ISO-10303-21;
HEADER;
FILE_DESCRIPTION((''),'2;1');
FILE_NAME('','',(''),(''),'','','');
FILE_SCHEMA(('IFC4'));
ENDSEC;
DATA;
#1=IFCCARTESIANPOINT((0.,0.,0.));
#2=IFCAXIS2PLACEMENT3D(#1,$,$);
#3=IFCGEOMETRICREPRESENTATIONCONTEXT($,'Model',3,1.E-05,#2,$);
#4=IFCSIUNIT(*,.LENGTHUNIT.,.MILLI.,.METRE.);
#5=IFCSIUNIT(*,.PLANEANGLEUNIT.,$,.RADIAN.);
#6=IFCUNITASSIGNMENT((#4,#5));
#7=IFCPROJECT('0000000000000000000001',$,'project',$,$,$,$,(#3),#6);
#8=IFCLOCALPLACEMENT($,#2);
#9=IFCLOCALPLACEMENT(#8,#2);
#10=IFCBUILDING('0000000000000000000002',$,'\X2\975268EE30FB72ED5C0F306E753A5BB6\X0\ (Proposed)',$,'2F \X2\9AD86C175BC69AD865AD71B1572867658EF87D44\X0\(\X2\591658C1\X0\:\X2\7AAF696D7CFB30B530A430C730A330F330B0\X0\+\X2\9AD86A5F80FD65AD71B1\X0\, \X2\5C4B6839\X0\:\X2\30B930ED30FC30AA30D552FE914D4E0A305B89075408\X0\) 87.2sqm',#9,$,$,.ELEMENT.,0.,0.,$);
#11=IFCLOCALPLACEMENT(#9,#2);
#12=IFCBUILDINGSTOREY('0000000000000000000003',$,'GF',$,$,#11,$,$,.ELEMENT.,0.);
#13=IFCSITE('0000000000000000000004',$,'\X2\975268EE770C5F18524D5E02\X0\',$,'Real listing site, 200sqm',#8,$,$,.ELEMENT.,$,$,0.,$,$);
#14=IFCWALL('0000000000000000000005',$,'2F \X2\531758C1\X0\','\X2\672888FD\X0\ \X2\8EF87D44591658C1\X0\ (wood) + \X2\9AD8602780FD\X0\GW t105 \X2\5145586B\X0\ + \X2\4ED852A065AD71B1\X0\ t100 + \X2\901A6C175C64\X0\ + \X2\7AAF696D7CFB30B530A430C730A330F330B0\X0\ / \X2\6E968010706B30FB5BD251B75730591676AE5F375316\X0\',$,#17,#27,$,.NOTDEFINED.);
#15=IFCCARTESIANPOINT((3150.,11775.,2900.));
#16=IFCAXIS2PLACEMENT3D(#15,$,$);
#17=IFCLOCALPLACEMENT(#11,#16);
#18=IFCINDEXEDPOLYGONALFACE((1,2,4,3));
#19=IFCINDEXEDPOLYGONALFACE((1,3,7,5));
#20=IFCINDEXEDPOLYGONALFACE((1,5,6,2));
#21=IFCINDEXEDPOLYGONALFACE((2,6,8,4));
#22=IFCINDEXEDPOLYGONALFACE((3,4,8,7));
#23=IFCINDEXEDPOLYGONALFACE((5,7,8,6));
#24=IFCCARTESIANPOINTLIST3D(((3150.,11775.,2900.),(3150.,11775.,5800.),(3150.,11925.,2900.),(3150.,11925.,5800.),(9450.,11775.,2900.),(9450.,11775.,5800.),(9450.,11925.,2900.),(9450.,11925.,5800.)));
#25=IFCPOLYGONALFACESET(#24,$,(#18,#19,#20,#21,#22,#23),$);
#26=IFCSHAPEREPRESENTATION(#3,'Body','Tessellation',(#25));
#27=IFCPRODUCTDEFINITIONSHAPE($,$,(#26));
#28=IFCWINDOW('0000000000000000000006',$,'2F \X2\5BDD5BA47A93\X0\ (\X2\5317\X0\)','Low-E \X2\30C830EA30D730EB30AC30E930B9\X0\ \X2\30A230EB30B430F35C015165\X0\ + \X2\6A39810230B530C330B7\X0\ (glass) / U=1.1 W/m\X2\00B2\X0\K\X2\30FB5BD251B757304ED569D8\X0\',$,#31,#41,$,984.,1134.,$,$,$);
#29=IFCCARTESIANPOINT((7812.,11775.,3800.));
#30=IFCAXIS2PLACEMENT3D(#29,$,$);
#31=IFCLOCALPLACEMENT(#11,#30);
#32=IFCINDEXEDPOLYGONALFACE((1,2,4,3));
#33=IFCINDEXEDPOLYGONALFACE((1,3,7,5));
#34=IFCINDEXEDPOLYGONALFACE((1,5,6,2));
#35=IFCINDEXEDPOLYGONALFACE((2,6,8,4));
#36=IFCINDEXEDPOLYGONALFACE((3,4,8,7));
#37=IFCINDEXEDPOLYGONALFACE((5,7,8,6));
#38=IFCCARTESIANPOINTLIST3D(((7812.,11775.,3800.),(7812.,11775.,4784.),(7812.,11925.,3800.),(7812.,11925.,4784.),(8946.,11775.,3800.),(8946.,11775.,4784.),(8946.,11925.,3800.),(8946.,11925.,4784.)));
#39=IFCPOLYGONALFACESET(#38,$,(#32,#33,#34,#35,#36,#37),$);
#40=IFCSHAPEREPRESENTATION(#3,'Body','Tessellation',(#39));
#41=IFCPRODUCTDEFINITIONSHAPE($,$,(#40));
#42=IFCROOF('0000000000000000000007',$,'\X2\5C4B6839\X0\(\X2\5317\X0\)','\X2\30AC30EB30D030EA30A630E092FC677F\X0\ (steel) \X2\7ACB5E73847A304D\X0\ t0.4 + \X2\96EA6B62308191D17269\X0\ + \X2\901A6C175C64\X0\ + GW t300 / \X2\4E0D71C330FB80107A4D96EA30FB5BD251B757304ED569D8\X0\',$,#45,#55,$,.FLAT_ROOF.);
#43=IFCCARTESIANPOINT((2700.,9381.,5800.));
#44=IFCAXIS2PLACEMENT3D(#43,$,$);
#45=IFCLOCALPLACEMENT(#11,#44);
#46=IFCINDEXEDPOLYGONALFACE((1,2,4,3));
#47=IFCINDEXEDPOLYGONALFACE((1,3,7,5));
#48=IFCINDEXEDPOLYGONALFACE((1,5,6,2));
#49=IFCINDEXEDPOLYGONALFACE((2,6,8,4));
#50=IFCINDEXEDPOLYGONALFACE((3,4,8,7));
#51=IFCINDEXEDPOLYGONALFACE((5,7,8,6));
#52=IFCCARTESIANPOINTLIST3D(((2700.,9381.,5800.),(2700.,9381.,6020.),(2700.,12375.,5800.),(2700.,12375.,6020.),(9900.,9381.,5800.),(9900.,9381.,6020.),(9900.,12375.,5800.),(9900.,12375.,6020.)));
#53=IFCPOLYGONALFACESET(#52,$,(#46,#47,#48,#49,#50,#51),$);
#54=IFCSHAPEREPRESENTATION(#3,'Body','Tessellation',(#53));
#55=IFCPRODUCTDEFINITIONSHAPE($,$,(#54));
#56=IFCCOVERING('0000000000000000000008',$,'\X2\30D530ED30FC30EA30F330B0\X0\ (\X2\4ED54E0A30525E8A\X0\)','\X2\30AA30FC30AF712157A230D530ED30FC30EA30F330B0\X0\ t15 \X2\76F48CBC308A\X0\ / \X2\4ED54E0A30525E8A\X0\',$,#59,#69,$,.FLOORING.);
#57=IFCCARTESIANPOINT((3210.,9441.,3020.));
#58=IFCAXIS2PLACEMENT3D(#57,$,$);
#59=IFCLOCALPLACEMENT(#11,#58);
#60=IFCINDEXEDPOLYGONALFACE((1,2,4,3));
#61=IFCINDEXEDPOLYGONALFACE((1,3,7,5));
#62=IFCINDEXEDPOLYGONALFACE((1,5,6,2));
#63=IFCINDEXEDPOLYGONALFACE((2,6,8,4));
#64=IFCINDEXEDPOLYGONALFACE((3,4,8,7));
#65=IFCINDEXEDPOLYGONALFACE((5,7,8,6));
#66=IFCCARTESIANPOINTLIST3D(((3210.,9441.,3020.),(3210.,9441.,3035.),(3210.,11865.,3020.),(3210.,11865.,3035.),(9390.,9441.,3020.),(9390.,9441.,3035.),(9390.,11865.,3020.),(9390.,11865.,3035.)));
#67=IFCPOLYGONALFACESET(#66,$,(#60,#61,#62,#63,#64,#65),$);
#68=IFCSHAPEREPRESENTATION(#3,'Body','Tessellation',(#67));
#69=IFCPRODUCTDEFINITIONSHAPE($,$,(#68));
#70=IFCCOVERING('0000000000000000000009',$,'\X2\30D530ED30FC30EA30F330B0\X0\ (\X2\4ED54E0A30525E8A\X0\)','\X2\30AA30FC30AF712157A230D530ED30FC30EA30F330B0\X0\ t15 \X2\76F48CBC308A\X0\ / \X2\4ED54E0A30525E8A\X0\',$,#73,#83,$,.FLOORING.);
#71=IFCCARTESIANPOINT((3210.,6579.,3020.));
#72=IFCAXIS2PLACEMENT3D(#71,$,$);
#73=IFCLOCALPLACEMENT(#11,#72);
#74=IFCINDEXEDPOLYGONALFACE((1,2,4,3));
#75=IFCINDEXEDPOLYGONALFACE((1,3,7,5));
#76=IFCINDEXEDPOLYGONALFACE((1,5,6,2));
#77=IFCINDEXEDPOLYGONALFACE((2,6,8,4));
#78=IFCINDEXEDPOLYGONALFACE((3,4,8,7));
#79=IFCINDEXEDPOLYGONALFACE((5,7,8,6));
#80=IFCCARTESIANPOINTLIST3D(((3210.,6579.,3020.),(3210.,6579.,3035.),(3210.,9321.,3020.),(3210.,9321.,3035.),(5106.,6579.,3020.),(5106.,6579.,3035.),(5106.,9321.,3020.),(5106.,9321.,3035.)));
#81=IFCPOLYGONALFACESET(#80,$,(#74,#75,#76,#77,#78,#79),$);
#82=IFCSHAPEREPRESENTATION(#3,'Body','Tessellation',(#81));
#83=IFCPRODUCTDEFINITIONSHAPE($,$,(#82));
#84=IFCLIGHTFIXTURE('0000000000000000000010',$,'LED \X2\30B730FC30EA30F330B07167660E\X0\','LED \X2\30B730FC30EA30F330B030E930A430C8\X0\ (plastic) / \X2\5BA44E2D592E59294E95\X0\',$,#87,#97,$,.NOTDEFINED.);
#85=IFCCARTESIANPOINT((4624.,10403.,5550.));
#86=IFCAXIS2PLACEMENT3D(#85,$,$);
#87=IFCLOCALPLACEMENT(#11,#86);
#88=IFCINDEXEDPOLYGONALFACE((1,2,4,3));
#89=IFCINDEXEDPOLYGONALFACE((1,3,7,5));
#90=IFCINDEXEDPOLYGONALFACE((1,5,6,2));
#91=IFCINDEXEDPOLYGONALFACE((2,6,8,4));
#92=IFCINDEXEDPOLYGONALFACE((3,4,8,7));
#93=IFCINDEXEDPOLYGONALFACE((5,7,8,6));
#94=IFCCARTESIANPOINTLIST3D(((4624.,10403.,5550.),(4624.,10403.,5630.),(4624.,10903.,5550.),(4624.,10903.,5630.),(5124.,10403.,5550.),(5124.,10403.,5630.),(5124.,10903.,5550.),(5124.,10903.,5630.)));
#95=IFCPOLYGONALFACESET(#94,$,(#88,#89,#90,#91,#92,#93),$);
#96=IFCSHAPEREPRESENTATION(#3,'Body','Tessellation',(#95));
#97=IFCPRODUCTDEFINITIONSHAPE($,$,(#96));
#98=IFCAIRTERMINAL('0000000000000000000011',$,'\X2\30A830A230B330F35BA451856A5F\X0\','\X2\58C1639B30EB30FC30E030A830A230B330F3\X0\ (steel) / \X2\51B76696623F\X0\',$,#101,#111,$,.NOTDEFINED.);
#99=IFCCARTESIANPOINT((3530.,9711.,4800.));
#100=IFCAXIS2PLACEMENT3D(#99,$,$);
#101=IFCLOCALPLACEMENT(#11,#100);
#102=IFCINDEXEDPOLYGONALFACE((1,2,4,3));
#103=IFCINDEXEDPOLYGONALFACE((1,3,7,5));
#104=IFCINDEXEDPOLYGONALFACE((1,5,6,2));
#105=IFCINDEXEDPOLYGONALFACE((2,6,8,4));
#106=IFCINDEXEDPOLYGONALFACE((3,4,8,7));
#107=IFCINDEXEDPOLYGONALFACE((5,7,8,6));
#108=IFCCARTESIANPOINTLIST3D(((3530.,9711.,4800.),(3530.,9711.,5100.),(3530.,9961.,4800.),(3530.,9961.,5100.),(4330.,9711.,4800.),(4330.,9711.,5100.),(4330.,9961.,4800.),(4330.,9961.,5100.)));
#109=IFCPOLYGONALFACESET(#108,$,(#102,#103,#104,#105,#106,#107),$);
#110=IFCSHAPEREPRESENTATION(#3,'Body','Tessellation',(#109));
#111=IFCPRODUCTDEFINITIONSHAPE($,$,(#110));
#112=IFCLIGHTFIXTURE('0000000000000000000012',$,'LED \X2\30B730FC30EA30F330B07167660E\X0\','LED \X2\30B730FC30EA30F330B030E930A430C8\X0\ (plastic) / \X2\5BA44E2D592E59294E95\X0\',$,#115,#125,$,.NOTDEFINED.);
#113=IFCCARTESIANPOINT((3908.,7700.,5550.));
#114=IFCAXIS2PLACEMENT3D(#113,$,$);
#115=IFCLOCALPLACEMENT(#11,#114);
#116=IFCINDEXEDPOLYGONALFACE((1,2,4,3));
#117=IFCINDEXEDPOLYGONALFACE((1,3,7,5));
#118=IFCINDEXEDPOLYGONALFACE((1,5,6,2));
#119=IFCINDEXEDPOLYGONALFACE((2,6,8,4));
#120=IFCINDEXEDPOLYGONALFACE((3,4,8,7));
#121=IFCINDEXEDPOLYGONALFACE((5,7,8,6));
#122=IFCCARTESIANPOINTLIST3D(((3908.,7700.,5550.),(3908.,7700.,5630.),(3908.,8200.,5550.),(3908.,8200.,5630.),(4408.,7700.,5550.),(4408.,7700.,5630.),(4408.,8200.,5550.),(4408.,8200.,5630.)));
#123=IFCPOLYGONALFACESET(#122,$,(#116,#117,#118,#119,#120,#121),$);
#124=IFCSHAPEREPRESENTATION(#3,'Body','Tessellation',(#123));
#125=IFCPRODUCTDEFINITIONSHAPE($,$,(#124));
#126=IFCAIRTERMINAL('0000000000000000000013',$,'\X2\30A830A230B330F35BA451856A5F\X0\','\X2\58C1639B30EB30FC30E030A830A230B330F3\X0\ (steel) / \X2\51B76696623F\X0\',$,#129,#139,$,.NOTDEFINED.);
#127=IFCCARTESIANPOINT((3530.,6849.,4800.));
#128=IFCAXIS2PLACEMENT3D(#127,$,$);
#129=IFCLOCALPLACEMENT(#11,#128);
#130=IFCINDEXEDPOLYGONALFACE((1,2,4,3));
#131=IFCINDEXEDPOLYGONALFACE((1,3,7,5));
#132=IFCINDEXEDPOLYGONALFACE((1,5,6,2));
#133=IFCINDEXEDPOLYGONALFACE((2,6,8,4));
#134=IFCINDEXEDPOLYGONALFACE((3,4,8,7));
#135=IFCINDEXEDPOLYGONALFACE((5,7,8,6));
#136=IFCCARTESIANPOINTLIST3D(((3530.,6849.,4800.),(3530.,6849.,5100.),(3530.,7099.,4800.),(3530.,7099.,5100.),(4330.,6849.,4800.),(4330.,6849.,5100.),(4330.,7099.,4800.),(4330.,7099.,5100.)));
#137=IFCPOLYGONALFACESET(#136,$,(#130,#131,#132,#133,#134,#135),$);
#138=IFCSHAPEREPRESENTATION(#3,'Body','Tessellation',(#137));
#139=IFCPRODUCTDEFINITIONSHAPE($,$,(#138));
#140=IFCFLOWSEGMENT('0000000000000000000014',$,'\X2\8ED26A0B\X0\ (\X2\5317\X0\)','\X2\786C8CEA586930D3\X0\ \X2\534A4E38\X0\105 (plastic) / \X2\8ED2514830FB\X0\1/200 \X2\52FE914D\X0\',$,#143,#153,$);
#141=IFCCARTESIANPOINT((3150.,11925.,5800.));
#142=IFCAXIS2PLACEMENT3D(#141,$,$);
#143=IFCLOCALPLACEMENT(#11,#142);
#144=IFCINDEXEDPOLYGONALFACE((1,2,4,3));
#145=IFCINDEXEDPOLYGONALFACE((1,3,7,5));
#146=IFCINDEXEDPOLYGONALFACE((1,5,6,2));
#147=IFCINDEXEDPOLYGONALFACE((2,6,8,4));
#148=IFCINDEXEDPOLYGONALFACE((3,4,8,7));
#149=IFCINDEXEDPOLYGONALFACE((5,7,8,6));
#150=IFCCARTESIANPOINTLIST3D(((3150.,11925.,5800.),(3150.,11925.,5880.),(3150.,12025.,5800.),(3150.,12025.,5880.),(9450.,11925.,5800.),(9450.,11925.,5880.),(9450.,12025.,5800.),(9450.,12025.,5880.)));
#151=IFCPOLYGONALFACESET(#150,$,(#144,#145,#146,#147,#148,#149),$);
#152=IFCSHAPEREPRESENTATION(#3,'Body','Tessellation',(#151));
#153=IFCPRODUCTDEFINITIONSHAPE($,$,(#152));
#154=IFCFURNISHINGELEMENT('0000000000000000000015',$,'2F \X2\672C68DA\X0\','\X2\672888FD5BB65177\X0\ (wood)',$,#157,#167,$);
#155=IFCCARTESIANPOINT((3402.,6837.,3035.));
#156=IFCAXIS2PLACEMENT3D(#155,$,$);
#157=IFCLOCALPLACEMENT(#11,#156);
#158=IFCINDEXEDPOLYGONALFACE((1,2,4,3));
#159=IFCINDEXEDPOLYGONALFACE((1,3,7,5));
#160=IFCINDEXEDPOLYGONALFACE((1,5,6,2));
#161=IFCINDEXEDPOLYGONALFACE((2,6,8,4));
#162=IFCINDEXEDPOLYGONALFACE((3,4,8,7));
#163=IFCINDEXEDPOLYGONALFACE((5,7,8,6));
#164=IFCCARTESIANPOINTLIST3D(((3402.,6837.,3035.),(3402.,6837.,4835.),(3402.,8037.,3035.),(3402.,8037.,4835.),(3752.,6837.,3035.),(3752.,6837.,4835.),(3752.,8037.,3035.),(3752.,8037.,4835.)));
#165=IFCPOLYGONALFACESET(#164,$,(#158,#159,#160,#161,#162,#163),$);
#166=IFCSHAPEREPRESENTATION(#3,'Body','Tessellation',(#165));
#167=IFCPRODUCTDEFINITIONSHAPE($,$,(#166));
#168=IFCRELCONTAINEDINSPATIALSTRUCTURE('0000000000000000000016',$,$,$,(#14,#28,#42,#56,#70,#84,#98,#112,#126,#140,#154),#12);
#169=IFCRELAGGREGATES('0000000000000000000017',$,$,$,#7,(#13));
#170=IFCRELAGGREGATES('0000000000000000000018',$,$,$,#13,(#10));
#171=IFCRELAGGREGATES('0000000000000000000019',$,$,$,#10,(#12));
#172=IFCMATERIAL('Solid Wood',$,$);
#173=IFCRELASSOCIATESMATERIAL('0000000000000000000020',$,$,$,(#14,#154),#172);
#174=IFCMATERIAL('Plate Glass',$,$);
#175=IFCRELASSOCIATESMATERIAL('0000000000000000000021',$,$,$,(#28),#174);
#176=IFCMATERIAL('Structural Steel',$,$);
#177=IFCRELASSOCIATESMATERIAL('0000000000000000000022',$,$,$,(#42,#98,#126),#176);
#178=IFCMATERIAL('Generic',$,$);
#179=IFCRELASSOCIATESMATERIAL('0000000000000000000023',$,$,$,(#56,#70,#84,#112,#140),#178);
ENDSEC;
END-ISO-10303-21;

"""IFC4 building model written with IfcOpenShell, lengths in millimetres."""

from ifc_helpers import new_model, si_unit, frame, frame_2d, origin, place, context, project, spatial, rectangle, extrude, material, element, fill, save


model = new_model("IFC4")

# Units and contexts
model_context = context("Model", 3, precision=1e-05, world=origin())
ifc_project = project(units=[si_unit("LENGTHUNIT", "METRE", prefix="MILLI"), si_unit("PLANEANGLEUNIT", "RADIAN")], contexts=[model_context])

# Site, building, storey
site_placement = place(None, origin())
site = spatial("IfcSite", under=ifc_project, at=site_placement, Name="青森県弘前市", ObjectType="Real listing site, 200sqm", CompositionType="ELEMENT", RefElevation=0.0)
building_placement = place(site_placement, origin())
building = spatial("IfcBuilding", under=site, at=building_placement, Name="青森・狭小の町家 (Proposed)", ObjectType="2F 高気密高断熱在来軸組(外壁:窯業系サイディング+高機能断熱, 屋根:スローオフ勾配上せ複合) 87.2sqm", CompositionType="ELEMENT", ElevationOfRefHeight=0.0, ElevationOfTerrain=0.0)
storey_placement = place(building_placement, origin())
storey = spatial("IfcBuildingStorey", under=building, at=storey_placement, Name="GF", CompositionType="ELEMENT", Elevation=0.0)

# Shared definitions
ifc_material_1 = material(Name="Solid Wood")

# Wall, opening, window
wall_placement = place(storey_placement, frame((3150.0, 11775.0, 2900.0)))
wall = element("IfcWall", 1, at=wall_placement, inside=storey, material=ifc_material_1, Name="2F 北壁", Description="木製 軸組外壁 (wood) + 高性能GW t105 充填 + 付加断熱 t100 + 通気層 + 窯業系サイディング / 準耐火・寒冷地外皮強化", PredefinedType="NOTDEFINED", context=model_context, shape_type="SweptSolid", body=[
    extrude(rectangle(XDim=6300.0, YDim=150.0, at=frame_2d((3150.0, 75.0))), frame((3150.0, 11775.0, 2900.0)), (0.0, 0.0, 1.0), 2900.0),
])
opening_placement = place(storey_placement, frame((7812.0, 11775.0, 3800.0)))
opening = element("IfcOpeningElement", 2, at=opening_placement, cuts=wall, PredefinedType="NOTDEFINED", context=model_context, shape_type="SweptSolid", body=[
    extrude(rectangle(XDim=1134.0, YDim=150.0, at=frame_2d((567.0, 75.0))), frame((7812.0, 11775.0, 3800.0)), (0.0, 0.0, 1.0), 984.0),
])
ifc_material_2 = material(Name="Plate Glass")
window_placement = place(storey_placement, frame((7812.0, 11775.0, 3800.0)))
window = element("IfcWindow", 3, at=window_placement, inside=storey, material=ifc_material_2, Name="2F 寝室窓 (北)", Description="Low-E トリプルガラス アルゴン封入 + 樹脂サッシ (glass) / U=1.1 W/m²K・寒冷地仕様", OverallHeight=984.0, OverallWidth=1134.0, context=model_context, shape_type="SweptSolid", body=[
    extrude(rectangle(XDim=1134.0, YDim=150.0, at=frame_2d((567.0, 75.0))), frame((7812.0, 11775.0, 3800.0)), (0.0, 0.0, 1.0), 984.0),
])
fill(opening, window)

# Roof
ifc_material_3 = material(Name="Structural Steel")
for number, where, name in (
    (4, (2700.0, 9381.0, 5800.0), "屋根(北)"),
):
    element("IfcRoof", number, at=place(storey_placement, frame(where)), inside=storey, material=ifc_material_3, Name=name, Description="ガルバリウム鋼板 (steel) 立平葺き t0.4 + 雪止め金物 + 通気層 + GW t300 / 不燃・耐積雪・寒冷地仕様", PredefinedType="FLAT_ROOF", context=model_context, shape_type="SweptSolid", body=[
        extrude(rectangle(XDim=7200.0, YDim=2994.0, at=frame_2d((3600.0, 1497.0))), frame((2700.0, 9381.0, 5800.0)), (0.0, 0.0, 1.0), 220.0),
    ])

# Coverings
ifc_material_4 = material(Name="Generic")
covering_1_placement = place(storey_placement, frame((3210.0, 9441.0, 3020.0)))
element("IfcCovering", 5, at=covering_1_placement, inside=storey, material=ifc_material_4, Name="フローリング (仕上げ床)", Description="オーク無垢フローリング t15 直貼り / 仕上げ床", PredefinedType="FLOORING", context=model_context, shape_type="SweptSolid", body=[
    extrude(rectangle(XDim=6180.0, YDim=2424.0, at=frame_2d((3090.0, 1212.0))), frame((3210.0, 9441.0, 3020.0)), (0.0, 0.0, 1.0), 15.0),
])
covering_2_placement = place(storey_placement, frame((3210.0, 6579.0, 3020.0)))
element("IfcCovering", 6, at=covering_2_placement, inside=storey, material=ifc_material_4, Name="フローリング (仕上げ床)", Description="オーク無垢フローリング t15 直貼り / 仕上げ床", PredefinedType="FLOORING", context=model_context, shape_type="SweptSolid", body=[
    extrude(rectangle(XDim=1896.0, YDim=2742.0, at=frame_2d((948.0, 1371.0))), frame((3210.0, 6579.0, 3020.0)), (0.0, 0.0, 1.0), 15.0),
])

# Light fixture
light_fixture_1_placement = place(storey_placement, frame((4624.0, 10403.0, 5550.0)))
element("IfcLightFixture", 7, at=light_fixture_1_placement, inside=storey, material=ifc_material_4, Name="LED シーリング照明", Description="LED シーリングライト (plastic) / 室中央天井", PredefinedType="NOTDEFINED", context=model_context, shape_type="SweptSolid", body=[
    extrude(rectangle(XDim=500.0, YDim=500.0, at=frame_2d((250.0, 250.0))), frame((4624.0, 10403.0, 5550.0)), (0.0, 0.0, 1.0), 80.0),
])

# Air terminal
air_terminal_1_placement = place(storey_placement, frame((3530.0, 9711.0, 4800.0)))
element("IfcAirTerminal", 8, at=air_terminal_1_placement, inside=storey, material=ifc_material_3, Name="エアコン室内機", Description="壁掛ルームエアコン (steel) / 冷暖房", PredefinedType="NOTDEFINED", context=model_context, shape_type="SweptSolid", body=[
    extrude(rectangle(XDim=800.0, YDim=250.0, at=frame_2d((400.0, 125.0))), frame((3530.0, 9711.0, 4800.0)), (0.0, 0.0, 1.0), 300.0),
])

# Light fixture
light_fixture_2_placement = place(storey_placement, frame((3908.0, 7700.0, 5550.0)))
element("IfcLightFixture", 9, at=light_fixture_2_placement, inside=storey, material=ifc_material_4, Name="LED シーリング照明", Description="LED シーリングライト (plastic) / 室中央天井", PredefinedType="NOTDEFINED", context=model_context, shape_type="SweptSolid", body=[
    extrude(rectangle(XDim=500.0, YDim=500.0, at=frame_2d((250.0, 250.0))), frame((3908.0, 7700.0, 5550.0)), (0.0, 0.0, 1.0), 80.0),
])

# Air terminal
air_terminal_2_placement = place(storey_placement, frame((3530.0, 6849.0, 4800.0)))
element("IfcAirTerminal", 10, at=air_terminal_2_placement, inside=storey, material=ifc_material_3, Name="エアコン室内機", Description="壁掛ルームエアコン (steel) / 冷暖房", PredefinedType="NOTDEFINED", context=model_context, shape_type="SweptSolid", body=[
    extrude(rectangle(XDim=800.0, YDim=250.0, at=frame_2d((400.0, 125.0))), frame((3530.0, 6849.0, 4800.0)), (0.0, 0.0, 1.0), 300.0),
])

# Flow segment
flow_segment_placement = place(storey_placement, frame((3150.0, 11925.0, 5800.0)))
element("IfcFlowSegment", 11, at=flow_segment_placement, inside=storey, material=ifc_material_4, Name="軒樋 (北)", Description="硬質塩ビ 半丸105 (plastic) / 軒先・1/200 勾配", context=model_context, shape_type="SweptSolid", body=[
    extrude(rectangle(XDim=6300.0, YDim=100.0, at=frame_2d((3150.0, 50.0))), frame((3150.0, 11925.0, 5800.0)), (0.0, 0.0, 1.0), 80.0),
])

# Furnishing element
furnishing_placement = place(storey_placement, frame((3402.0, 6837.0, 3035.0)))
element("IfcFurnishingElement", 12, at=furnishing_placement, inside=storey, material=ifc_material_1, Name="2F 本棚", Description="木製家具 (wood)", context=model_context, shape_type="SweptSolid", body=[
    extrude(rectangle(XDim=350.0, YDim=1200.0, at=frame_2d((175.0, 600.0))), frame((3402.0, 6837.0, 3035.0)), (0.0, 0.0, 1.0), 1800.0),
])

save(model, "model.ifc")
